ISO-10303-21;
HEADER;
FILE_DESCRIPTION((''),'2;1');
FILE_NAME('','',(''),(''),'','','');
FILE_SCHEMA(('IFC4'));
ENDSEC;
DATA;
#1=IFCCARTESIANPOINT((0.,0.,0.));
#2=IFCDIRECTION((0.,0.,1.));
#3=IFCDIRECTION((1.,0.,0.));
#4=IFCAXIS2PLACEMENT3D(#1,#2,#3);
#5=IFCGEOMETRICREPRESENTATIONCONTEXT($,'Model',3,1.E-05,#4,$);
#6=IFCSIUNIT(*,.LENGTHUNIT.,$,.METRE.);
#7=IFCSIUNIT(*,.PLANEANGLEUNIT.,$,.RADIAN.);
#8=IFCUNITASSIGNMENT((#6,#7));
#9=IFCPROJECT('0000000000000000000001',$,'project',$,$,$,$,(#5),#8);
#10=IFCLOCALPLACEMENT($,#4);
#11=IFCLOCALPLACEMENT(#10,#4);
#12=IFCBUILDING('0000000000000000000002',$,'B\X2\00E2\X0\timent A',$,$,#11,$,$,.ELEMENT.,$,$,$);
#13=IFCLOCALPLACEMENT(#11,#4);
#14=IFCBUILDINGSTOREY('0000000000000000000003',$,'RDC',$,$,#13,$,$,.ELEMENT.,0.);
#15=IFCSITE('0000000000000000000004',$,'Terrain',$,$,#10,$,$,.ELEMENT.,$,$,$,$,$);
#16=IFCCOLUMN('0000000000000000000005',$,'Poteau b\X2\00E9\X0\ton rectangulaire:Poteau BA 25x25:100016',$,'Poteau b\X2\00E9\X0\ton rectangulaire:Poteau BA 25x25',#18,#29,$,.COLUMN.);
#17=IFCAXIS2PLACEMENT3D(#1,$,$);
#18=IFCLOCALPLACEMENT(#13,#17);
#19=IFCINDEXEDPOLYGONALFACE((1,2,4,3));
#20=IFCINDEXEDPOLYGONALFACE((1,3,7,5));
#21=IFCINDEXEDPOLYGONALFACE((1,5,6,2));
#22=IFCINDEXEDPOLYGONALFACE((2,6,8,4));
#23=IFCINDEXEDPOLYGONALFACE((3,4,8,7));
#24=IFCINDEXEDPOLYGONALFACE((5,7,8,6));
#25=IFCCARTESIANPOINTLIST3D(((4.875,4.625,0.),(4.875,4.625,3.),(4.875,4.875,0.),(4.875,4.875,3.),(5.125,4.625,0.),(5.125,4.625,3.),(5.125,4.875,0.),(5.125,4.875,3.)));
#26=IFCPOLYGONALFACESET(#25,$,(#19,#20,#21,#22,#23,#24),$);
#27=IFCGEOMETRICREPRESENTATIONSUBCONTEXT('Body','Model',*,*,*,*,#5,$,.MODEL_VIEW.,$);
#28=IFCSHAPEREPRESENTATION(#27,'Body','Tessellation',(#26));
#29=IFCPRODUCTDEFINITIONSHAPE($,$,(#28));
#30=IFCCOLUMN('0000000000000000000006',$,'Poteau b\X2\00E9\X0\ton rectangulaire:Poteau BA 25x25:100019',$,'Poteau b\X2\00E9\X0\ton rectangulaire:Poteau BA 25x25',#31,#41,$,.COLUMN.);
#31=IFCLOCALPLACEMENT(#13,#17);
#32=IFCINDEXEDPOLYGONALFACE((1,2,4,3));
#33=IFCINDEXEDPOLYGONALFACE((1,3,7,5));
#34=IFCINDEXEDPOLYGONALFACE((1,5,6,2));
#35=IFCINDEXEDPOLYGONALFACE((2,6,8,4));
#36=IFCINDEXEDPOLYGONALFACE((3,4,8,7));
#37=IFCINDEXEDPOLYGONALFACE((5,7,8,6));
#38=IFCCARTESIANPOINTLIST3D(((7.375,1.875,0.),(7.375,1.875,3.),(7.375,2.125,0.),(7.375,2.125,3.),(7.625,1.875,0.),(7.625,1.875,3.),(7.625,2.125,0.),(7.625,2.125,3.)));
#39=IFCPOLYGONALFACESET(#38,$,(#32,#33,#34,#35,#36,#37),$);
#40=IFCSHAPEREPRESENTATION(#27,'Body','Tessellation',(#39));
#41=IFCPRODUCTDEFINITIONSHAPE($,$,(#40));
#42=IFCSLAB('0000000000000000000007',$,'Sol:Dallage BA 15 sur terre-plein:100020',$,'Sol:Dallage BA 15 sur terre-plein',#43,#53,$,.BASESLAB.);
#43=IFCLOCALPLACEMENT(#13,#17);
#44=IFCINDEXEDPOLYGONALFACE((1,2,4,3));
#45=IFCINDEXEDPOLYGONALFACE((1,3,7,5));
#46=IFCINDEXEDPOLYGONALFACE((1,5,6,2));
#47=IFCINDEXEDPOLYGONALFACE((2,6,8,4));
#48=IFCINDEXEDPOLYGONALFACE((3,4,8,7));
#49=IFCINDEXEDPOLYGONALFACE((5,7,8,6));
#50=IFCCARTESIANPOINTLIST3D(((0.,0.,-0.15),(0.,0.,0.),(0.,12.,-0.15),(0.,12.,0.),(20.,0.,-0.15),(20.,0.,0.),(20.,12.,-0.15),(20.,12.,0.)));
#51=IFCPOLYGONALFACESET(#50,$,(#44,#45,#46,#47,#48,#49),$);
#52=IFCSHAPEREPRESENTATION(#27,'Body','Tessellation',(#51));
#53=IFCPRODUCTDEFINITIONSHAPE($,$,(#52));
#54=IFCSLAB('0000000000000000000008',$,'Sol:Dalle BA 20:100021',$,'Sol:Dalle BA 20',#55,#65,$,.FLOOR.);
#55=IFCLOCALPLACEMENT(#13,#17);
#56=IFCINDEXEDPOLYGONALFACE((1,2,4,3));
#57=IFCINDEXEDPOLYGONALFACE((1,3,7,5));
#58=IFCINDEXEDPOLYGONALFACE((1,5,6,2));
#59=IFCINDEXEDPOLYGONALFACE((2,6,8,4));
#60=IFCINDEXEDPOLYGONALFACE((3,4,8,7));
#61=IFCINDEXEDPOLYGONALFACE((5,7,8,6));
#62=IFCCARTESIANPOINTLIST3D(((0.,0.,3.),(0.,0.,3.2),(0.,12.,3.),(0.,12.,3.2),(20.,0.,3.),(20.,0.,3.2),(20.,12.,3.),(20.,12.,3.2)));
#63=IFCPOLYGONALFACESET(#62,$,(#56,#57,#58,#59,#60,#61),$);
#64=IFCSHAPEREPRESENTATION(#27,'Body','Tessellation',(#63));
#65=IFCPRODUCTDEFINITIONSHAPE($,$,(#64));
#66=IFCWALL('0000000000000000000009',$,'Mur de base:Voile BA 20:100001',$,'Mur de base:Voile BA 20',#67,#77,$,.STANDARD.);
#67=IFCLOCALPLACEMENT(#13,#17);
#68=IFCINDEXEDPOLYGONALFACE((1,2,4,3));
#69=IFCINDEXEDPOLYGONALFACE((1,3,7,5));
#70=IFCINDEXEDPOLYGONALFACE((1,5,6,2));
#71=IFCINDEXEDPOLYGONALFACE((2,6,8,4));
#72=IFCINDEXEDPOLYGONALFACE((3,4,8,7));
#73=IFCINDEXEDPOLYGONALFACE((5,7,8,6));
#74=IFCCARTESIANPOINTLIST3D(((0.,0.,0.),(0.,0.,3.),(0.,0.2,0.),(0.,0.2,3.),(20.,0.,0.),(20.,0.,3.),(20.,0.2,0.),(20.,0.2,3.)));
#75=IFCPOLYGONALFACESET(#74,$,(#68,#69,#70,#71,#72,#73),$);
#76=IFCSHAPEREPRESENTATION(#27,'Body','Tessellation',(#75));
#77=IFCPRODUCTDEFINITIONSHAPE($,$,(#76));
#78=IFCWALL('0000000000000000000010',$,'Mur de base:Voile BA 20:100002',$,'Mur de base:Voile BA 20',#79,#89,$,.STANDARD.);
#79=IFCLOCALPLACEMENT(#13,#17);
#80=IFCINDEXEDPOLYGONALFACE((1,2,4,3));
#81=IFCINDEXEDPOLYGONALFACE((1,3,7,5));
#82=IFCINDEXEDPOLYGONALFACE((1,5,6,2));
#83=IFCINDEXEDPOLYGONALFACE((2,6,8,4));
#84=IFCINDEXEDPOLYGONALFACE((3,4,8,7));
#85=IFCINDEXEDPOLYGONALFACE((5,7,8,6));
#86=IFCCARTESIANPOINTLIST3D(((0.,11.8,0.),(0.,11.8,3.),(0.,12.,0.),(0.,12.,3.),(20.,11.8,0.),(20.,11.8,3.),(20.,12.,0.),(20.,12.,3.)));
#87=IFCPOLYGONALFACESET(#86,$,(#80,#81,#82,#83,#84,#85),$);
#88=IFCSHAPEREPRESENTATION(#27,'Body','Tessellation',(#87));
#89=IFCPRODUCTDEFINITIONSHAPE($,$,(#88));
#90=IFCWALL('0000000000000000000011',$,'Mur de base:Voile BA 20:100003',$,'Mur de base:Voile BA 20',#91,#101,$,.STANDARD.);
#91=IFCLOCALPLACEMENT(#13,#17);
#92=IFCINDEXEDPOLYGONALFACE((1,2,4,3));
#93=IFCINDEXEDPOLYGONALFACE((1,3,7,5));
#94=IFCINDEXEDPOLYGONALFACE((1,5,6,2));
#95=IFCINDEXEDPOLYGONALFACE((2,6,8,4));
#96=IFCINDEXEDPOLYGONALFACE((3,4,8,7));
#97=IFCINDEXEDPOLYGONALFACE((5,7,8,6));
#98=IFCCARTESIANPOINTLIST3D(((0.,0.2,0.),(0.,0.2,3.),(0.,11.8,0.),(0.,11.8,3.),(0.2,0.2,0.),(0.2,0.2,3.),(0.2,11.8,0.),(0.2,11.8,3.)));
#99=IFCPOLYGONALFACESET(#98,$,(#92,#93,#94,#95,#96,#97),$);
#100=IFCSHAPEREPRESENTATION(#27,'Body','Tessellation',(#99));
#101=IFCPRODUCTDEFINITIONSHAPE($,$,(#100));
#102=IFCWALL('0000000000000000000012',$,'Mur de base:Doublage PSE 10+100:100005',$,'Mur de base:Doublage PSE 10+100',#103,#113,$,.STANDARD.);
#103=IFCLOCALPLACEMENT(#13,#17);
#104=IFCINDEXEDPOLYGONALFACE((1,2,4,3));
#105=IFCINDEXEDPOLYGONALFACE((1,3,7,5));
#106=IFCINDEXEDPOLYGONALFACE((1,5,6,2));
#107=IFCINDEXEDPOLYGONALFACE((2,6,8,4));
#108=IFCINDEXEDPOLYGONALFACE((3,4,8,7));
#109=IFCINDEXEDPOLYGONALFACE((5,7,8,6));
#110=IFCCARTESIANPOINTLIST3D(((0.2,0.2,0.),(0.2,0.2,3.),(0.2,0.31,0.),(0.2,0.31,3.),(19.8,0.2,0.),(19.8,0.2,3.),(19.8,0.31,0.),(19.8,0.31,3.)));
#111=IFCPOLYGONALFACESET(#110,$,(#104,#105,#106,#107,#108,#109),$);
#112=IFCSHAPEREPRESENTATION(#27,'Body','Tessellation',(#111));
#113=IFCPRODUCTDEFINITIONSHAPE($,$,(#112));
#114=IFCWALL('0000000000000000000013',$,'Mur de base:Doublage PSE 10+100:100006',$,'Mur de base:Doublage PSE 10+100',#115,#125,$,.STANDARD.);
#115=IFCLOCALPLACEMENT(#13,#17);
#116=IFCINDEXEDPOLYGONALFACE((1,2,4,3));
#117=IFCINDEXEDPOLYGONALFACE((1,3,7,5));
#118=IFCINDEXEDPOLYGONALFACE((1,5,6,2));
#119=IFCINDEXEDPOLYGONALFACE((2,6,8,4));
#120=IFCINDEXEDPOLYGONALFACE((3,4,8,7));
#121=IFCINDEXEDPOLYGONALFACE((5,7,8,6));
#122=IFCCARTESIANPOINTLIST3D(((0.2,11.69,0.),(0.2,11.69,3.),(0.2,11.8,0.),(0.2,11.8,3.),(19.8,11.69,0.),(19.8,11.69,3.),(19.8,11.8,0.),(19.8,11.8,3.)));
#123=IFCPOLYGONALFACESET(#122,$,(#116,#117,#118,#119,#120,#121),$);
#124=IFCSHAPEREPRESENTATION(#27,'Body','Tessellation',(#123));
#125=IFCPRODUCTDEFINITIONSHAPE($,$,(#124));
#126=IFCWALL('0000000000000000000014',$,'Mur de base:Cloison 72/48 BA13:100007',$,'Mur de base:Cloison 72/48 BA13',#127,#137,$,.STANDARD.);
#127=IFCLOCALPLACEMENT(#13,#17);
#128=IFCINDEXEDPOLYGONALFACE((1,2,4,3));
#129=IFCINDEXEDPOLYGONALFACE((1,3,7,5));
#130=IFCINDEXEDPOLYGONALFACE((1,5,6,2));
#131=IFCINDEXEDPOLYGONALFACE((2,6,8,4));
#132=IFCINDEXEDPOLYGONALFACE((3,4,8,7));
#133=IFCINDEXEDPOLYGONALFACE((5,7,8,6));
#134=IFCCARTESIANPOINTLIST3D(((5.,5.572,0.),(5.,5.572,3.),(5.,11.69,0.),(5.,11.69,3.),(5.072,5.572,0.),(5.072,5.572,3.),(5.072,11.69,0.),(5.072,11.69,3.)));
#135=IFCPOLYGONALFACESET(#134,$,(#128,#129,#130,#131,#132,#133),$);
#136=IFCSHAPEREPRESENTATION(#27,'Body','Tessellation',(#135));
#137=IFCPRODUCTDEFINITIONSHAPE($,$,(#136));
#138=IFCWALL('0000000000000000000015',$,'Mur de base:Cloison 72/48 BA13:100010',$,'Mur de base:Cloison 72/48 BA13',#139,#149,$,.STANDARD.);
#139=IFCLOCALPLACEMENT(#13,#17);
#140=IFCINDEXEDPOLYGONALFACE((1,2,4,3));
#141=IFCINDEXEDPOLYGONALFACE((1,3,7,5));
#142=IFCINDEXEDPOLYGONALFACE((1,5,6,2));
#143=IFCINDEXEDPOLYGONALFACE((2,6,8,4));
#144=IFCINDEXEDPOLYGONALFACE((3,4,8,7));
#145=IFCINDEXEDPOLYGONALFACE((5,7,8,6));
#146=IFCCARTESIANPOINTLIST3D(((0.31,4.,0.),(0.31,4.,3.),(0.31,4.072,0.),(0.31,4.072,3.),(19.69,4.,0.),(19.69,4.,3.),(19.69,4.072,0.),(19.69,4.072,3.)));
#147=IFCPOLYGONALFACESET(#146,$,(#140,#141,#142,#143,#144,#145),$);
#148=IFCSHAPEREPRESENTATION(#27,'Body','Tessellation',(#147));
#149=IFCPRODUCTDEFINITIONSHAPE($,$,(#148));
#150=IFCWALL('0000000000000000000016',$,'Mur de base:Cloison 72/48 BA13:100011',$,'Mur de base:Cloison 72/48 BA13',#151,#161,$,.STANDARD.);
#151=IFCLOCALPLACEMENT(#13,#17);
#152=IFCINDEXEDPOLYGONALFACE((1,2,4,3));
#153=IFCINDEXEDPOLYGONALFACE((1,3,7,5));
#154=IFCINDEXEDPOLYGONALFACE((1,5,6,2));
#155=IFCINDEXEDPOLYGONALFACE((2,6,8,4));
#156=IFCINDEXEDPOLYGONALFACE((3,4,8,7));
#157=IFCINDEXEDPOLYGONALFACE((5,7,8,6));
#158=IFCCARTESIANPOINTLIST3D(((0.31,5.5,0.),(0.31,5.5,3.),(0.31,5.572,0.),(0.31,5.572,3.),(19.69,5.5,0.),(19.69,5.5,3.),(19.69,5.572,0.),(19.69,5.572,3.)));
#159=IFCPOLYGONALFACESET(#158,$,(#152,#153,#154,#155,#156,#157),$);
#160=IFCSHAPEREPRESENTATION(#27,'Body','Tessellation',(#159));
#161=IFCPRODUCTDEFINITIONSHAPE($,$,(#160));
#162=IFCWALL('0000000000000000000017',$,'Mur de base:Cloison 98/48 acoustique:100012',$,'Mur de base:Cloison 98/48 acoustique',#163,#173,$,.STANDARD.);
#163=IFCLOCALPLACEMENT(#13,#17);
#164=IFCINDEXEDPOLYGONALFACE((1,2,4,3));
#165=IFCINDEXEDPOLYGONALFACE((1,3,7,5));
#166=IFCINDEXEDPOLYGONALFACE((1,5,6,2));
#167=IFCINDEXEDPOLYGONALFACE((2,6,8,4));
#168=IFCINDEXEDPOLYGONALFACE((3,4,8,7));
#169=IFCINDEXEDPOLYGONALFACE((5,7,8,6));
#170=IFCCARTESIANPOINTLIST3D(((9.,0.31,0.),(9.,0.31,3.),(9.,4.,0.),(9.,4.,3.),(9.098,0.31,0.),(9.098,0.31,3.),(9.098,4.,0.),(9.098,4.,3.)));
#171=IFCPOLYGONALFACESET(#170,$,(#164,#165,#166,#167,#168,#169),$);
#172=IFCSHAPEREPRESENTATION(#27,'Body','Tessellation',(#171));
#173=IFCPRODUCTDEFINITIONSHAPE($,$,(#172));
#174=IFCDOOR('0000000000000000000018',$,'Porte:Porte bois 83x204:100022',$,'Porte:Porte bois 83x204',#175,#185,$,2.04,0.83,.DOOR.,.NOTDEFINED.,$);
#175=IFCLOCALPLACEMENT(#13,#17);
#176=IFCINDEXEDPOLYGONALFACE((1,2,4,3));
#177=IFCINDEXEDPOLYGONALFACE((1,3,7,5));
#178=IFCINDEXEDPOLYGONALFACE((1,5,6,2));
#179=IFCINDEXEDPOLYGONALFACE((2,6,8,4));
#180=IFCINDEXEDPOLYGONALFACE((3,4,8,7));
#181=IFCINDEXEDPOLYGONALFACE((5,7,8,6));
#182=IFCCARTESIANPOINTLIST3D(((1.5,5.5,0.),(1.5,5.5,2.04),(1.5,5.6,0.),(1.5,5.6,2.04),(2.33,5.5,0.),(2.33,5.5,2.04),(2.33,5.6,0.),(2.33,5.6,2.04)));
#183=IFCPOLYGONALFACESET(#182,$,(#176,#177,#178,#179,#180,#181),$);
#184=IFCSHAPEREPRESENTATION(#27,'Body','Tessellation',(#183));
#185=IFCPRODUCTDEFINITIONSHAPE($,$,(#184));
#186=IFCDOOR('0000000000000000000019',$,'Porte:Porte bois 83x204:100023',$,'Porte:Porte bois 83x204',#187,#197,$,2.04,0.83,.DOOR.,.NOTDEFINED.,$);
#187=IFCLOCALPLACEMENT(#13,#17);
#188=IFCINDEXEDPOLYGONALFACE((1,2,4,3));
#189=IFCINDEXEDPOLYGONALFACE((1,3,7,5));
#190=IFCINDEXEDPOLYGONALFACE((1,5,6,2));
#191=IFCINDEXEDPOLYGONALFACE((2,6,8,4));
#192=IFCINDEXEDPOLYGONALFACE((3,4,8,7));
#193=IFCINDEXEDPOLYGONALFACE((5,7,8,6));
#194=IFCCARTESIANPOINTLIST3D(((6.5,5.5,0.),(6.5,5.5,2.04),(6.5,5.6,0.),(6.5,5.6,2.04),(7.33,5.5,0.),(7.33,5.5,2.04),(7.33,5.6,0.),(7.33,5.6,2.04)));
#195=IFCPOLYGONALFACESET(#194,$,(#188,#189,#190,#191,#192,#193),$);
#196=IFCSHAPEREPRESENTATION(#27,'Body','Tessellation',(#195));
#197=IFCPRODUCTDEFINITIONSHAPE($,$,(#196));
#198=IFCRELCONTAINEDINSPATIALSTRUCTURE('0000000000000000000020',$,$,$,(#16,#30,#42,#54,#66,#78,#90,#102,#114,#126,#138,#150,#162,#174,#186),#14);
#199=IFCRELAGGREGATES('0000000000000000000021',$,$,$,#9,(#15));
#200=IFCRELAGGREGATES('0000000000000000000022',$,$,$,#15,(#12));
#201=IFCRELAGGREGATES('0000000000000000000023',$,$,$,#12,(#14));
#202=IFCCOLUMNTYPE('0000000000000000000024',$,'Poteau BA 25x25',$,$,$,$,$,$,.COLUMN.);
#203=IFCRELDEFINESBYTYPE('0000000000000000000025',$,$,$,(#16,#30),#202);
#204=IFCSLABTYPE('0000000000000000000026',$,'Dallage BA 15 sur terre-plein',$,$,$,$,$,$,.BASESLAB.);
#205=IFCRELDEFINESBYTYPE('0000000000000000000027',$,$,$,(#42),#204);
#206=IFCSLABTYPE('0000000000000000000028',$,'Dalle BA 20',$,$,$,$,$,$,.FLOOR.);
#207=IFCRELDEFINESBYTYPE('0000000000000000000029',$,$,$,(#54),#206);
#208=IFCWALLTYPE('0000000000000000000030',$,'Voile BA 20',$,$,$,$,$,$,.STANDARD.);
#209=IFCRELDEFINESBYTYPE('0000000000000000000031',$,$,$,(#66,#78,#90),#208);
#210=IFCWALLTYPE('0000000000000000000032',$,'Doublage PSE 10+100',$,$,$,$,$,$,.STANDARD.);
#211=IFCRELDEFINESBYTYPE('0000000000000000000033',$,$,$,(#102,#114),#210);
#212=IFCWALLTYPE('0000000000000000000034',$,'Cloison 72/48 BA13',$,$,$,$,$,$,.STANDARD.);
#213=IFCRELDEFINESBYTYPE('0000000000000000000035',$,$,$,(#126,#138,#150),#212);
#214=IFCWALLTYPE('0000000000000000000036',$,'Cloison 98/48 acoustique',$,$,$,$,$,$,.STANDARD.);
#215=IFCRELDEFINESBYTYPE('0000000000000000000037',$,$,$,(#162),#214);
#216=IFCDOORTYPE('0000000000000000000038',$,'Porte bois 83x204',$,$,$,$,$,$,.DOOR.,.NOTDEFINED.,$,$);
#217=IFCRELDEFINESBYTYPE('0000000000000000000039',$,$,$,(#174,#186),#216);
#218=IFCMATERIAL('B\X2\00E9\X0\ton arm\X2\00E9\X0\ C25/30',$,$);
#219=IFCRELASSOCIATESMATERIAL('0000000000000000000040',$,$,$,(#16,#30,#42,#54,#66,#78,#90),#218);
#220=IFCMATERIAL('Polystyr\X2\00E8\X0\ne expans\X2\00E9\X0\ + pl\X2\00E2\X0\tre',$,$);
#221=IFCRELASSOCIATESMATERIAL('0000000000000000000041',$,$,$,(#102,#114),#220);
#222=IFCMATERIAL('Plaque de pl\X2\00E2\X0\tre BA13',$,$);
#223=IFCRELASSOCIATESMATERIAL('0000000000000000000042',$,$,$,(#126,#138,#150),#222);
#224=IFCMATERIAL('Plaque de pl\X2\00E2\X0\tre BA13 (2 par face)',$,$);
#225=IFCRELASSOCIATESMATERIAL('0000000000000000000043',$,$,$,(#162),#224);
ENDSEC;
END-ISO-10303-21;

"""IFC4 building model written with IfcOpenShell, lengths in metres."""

from ifc_helpers import new_model, si_unit, frame, frame_2d, origin_with_axes, place, context, subcontext, project, spatial, rectangle, extrude, material, type_object, element, save


model = new_model("IFC4")

# Units and contexts
model_context = context("Model", 3, precision=1e-05, world=origin_with_axes())
body_context = subcontext(model_context, "Body", "Model", "MODEL_VIEW")
ifc_project = project(units=[si_unit("LENGTHUNIT", "METRE"), si_unit("PLANEANGLEUNIT", "RADIAN")], contexts=[model_context])

# Site, building, storey
site_placement = place(None, origin_with_axes())
site = spatial("IfcSite", under=ifc_project, at=site_placement, Name="Terrain", CompositionType="ELEMENT")
building_placement = place(site_placement, origin_with_axes())
building = spatial("IfcBuilding", under=site, at=building_placement, Name="Bâtiment A", CompositionType="ELEMENT")
storey_placement = place(building_placement, origin_with_axes())
storey = spatial("IfcBuildingStorey", under=building, at=storey_placement, Name="RDC", CompositionType="ELEMENT", Elevation=0.0)

# Columns
ifc_material_1 = material(Name="Béton armé C25/30")
column_type = type_object("IfcColumnType", Name="Poteau BA 25x25", PredefinedType="COLUMN")
for number, where, z_axis, x_axis, name in (
    (1, (4.875, 4.625, 0.0), (0.0, 0.0, 1.0), (1.0, 0.0, 0.0), "Poteau béton rectangulaire:Poteau BA 25x25:100016"),
    (2, (7.375, 1.875, 0.0), (0.0, 0.0, 1.0), (1.0, 0.0, 0.0), "Poteau béton rectangulaire:Poteau BA 25x25:100019"),
):
    element("IfcColumn", number, at=place(storey_placement, frame(where, z_axis=z_axis, x_axis=x_axis)), inside=storey, type_object=column_type, material=ifc_material_1, Name=name, ObjectType="Poteau béton rectangulaire:Poteau BA 25x25", PredefinedType="COLUMN", context=body_context, shape_type="SweptSolid", body=[
        extrude(rectangle(XDim=0.25, YDim=0.25, at=frame_2d((0.125, 0.125))), origin_with_axes(), (0.0, 0.0, 1.0), 3.0),
    ])

# Slabs
slab_type_1 = type_object("IfcSlabType", Name="Dallage BA 15 sur terre-plein", PredefinedType="BASESLAB")
slab_1_placement = place(storey_placement, frame((0.0, 0.0, -0.15), z_axis=(0.0, 0.0, 1.0), x_axis=(1.0, 0.0, 0.0)))
element("IfcSlab", 3, at=slab_1_placement, inside=storey, type_object=slab_type_1, material=ifc_material_1, Name="Sol:Dallage BA 15 sur terre-plein:100020", ObjectType="Sol:Dallage BA 15 sur terre-plein", PredefinedType="BASESLAB", context=body_context, shape_type="SweptSolid", body=[
    extrude(rectangle(XDim=20.0, YDim=12.0, at=frame_2d((10.0, 6.0))), origin_with_axes(), (0.0, 0.0, 1.0), 0.15),
])
slab_type_2 = type_object("IfcSlabType", Name="Dalle BA 20", PredefinedType="FLOOR")
slab_2_placement = place(storey_placement, frame((0.0, 0.0, 3.0), z_axis=(0.0, 0.0, 1.0), x_axis=(1.0, 0.0, 0.0)))
element("IfcSlab", 4, at=slab_2_placement, inside=storey, type_object=slab_type_2, material=ifc_material_1, Name="Sol:Dalle BA 20:100021", ObjectType="Sol:Dalle BA 20", PredefinedType="FLOOR", context=body_context, shape_type="SweptSolid", body=[
    extrude(rectangle(XDim=20.0, YDim=12.0, at=frame_2d((10.0, 6.0))), origin_with_axes(), (0.0, 0.0, 1.0), 0.2),
])

# Walls
wall_type_1 = type_object("IfcWallType", Name="Voile BA 20", PredefinedType="STANDARD")
for number, where, z_axis, x_axis, name in (
    (5, (0.0, 0.0, 0.0), (0.0, 0.0, 1.0), (1.0, 0.0, 0.0), "Mur de base:Voile BA 20:100001"),
    (6, (0.0, 11.8, 0.0), (0.0, 0.0, 1.0), (1.0, 0.0, 0.0), "Mur de base:Voile BA 20:100002"),
):
    element("IfcWall", number, at=place(storey_placement, frame(where, z_axis=z_axis, x_axis=x_axis)), inside=storey, type_object=wall_type_1, material=ifc_material_1, Name=name, ObjectType="Mur de base:Voile BA 20", PredefinedType="STANDARD", context=body_context, shape_type="SweptSolid", body=[
        extrude(rectangle(XDim=20.0, YDim=0.2, at=frame_2d((10.0, 0.1))), origin_with_axes(), (0.0, 0.0, 1.0), 3.0),
    ])
wall_1_placement = place(storey_placement, frame((0.2, 0.2, 0.0), z_axis=(0.0, 0.0, 1.0), x_axis=(0.0, 1.0, 0.0)))
element("IfcWall", 7, at=wall_1_placement, inside=storey, type_object=wall_type_1, material=ifc_material_1, Name="Mur de base:Voile BA 20:100003", ObjectType="Mur de base:Voile BA 20", PredefinedType="STANDARD", context=body_context, shape_type="SweptSolid", body=[
    extrude(rectangle(XDim=11.6, YDim=0.2, at=frame_2d((5.8, 0.1))), origin_with_axes(), (0.0, 0.0, 1.0), 3.0),
])
ifc_material_2 = material(Name="Polystyrène expansé + plâtre")
wall_type_2 = type_object("IfcWallType", Name="Doublage PSE 10+100", PredefinedType="STANDARD")
for number, where, z_axis, x_axis, name in (
    (8, (0.2, 0.2, 0.0), (0.0, 0.0, 1.0), (1.0, 0.0, 0.0), "Mur de base:Doublage PSE 10+100:100005"),
    (9, (0.2, 11.69, 0.0), (0.0, 0.0, 1.0), (1.0, 0.0, 0.0), "Mur de base:Doublage PSE 10+100:100006"),
):
    element("IfcWall", number, at=place(storey_placement, frame(where, z_axis=z_axis, x_axis=x_axis)), inside=storey, type_object=wall_type_2, material=ifc_material_2, Name=name, ObjectType="Mur de base:Doublage PSE 10+100", PredefinedType="STANDARD", context=body_context, shape_type="SweptSolid", body=[
        extrude(rectangle(XDim=19.6, YDim=0.11, at=frame_2d((9.8, 0.055))), origin_with_axes(), (0.0, 0.0, 1.0), 3.0),
    ])
ifc_material_3 = material(Name="Plaque de plâtre BA13")
wall_type_3 = type_object("IfcWallType", Name="Cloison 72/48 BA13", PredefinedType="STANDARD")
wall_2_placement = place(storey_placement, frame((5.072, 5.572, 0.0), z_axis=(0.0, 0.0, 1.0), x_axis=(0.0, 1.0, 0.0)))
element("IfcWall", 10, at=wall_2_placement, inside=storey, type_object=wall_type_3, material=ifc_material_3, Name="Mur de base:Cloison 72/48 BA13:100007", ObjectType="Mur de base:Cloison 72/48 BA13", PredefinedType="STANDARD", context=body_context, shape_type="SweptSolid", body=[
    extrude(rectangle(XDim=6.118, YDim=0.072, at=frame_2d((3.059, 0.036))), origin_with_axes(), (0.0, 0.0, 1.0), 3.0),
])
for number, where, z_axis, x_axis, name in (
    (11, (0.31, 4.0, 0.0), (0.0, 0.0, 1.0), (1.0, 0.0, 0.0), "Mur de base:Cloison 72/48 BA13:100010"),
    (12, (0.31, 5.5, 0.0), (0.0, 0.0, 1.0), (1.0, 0.0, 0.0), "Mur de base:Cloison 72/48 BA13:100011"),
):
    element("IfcWall", number, at=place(storey_placement, frame(where, z_axis=z_axis, x_axis=x_axis)), inside=storey, type_object=wall_type_3, material=ifc_material_3, Name=name, ObjectType="Mur de base:Cloison 72/48 BA13", PredefinedType="STANDARD", context=body_context, shape_type="SweptSolid", body=[
        extrude(rectangle(XDim=19.38, YDim=0.072, at=frame_2d((9.69, 0.036))), origin_with_axes(), (0.0, 0.0, 1.0), 3.0),
    ])
ifc_material_4 = material(Name="Plaque de plâtre BA13 (2 par face)")
wall_type_4 = type_object("IfcWallType", Name="Cloison 98/48 acoustique", PredefinedType="STANDARD")
wall_3_placement = place(storey_placement, frame((9.098, 0.31, 0.0), z_axis=(0.0, 0.0, 1.0), x_axis=(0.0, 1.0, 0.0)))
element("IfcWall", 13, at=wall_3_placement, inside=storey, type_object=wall_type_4, material=ifc_material_4, Name="Mur de base:Cloison 98/48 acoustique:100012", ObjectType="Mur de base:Cloison 98/48 acoustique", PredefinedType="STANDARD", context=body_context, shape_type="SweptSolid", body=[
    extrude(rectangle(XDim=3.69, YDim=0.098, at=frame_2d((1.845, 0.049))), origin_with_axes(), (0.0, 0.0, 1.0), 3.0),
])

# Doors
door_type_1 = type_object("IfcDoorType", Name="Porte bois 83x204", OperationType="NOTDEFINED", PredefinedType="DOOR")
for number, where, z_axis, x_axis, name in (
    (14, (1.5, 5.5, 0.0), (0.0, 0.0, 1.0), (1.0, 0.0, 0.0), "Porte:Porte bois 83x204:100022"),
    (15, (6.5, 5.5, 0.0), (0.0, 0.0, 1.0), (1.0, 0.0, 0.0), "Porte:Porte bois 83x204:100023"),
):
    element("IfcDoor", number, at=place(storey_placement, frame(where, z_axis=z_axis, x_axis=x_axis)), inside=storey, type_object=door_type_1, Name=name, ObjectType="Porte:Porte bois 83x204", OperationType="NOTDEFINED", OverallHeight=2.04, OverallWidth=0.83, PredefinedType="DOOR", context=body_context, shape_type="SweptSolid", body=[
        extrude(rectangle(XDim=0.83, YDim=0.1, at=frame_2d((0.415, 0.05))), origin_with_axes(), (0.0, 0.0, 1.0), 2.04),
    ])

save(model, "model.ifc")
